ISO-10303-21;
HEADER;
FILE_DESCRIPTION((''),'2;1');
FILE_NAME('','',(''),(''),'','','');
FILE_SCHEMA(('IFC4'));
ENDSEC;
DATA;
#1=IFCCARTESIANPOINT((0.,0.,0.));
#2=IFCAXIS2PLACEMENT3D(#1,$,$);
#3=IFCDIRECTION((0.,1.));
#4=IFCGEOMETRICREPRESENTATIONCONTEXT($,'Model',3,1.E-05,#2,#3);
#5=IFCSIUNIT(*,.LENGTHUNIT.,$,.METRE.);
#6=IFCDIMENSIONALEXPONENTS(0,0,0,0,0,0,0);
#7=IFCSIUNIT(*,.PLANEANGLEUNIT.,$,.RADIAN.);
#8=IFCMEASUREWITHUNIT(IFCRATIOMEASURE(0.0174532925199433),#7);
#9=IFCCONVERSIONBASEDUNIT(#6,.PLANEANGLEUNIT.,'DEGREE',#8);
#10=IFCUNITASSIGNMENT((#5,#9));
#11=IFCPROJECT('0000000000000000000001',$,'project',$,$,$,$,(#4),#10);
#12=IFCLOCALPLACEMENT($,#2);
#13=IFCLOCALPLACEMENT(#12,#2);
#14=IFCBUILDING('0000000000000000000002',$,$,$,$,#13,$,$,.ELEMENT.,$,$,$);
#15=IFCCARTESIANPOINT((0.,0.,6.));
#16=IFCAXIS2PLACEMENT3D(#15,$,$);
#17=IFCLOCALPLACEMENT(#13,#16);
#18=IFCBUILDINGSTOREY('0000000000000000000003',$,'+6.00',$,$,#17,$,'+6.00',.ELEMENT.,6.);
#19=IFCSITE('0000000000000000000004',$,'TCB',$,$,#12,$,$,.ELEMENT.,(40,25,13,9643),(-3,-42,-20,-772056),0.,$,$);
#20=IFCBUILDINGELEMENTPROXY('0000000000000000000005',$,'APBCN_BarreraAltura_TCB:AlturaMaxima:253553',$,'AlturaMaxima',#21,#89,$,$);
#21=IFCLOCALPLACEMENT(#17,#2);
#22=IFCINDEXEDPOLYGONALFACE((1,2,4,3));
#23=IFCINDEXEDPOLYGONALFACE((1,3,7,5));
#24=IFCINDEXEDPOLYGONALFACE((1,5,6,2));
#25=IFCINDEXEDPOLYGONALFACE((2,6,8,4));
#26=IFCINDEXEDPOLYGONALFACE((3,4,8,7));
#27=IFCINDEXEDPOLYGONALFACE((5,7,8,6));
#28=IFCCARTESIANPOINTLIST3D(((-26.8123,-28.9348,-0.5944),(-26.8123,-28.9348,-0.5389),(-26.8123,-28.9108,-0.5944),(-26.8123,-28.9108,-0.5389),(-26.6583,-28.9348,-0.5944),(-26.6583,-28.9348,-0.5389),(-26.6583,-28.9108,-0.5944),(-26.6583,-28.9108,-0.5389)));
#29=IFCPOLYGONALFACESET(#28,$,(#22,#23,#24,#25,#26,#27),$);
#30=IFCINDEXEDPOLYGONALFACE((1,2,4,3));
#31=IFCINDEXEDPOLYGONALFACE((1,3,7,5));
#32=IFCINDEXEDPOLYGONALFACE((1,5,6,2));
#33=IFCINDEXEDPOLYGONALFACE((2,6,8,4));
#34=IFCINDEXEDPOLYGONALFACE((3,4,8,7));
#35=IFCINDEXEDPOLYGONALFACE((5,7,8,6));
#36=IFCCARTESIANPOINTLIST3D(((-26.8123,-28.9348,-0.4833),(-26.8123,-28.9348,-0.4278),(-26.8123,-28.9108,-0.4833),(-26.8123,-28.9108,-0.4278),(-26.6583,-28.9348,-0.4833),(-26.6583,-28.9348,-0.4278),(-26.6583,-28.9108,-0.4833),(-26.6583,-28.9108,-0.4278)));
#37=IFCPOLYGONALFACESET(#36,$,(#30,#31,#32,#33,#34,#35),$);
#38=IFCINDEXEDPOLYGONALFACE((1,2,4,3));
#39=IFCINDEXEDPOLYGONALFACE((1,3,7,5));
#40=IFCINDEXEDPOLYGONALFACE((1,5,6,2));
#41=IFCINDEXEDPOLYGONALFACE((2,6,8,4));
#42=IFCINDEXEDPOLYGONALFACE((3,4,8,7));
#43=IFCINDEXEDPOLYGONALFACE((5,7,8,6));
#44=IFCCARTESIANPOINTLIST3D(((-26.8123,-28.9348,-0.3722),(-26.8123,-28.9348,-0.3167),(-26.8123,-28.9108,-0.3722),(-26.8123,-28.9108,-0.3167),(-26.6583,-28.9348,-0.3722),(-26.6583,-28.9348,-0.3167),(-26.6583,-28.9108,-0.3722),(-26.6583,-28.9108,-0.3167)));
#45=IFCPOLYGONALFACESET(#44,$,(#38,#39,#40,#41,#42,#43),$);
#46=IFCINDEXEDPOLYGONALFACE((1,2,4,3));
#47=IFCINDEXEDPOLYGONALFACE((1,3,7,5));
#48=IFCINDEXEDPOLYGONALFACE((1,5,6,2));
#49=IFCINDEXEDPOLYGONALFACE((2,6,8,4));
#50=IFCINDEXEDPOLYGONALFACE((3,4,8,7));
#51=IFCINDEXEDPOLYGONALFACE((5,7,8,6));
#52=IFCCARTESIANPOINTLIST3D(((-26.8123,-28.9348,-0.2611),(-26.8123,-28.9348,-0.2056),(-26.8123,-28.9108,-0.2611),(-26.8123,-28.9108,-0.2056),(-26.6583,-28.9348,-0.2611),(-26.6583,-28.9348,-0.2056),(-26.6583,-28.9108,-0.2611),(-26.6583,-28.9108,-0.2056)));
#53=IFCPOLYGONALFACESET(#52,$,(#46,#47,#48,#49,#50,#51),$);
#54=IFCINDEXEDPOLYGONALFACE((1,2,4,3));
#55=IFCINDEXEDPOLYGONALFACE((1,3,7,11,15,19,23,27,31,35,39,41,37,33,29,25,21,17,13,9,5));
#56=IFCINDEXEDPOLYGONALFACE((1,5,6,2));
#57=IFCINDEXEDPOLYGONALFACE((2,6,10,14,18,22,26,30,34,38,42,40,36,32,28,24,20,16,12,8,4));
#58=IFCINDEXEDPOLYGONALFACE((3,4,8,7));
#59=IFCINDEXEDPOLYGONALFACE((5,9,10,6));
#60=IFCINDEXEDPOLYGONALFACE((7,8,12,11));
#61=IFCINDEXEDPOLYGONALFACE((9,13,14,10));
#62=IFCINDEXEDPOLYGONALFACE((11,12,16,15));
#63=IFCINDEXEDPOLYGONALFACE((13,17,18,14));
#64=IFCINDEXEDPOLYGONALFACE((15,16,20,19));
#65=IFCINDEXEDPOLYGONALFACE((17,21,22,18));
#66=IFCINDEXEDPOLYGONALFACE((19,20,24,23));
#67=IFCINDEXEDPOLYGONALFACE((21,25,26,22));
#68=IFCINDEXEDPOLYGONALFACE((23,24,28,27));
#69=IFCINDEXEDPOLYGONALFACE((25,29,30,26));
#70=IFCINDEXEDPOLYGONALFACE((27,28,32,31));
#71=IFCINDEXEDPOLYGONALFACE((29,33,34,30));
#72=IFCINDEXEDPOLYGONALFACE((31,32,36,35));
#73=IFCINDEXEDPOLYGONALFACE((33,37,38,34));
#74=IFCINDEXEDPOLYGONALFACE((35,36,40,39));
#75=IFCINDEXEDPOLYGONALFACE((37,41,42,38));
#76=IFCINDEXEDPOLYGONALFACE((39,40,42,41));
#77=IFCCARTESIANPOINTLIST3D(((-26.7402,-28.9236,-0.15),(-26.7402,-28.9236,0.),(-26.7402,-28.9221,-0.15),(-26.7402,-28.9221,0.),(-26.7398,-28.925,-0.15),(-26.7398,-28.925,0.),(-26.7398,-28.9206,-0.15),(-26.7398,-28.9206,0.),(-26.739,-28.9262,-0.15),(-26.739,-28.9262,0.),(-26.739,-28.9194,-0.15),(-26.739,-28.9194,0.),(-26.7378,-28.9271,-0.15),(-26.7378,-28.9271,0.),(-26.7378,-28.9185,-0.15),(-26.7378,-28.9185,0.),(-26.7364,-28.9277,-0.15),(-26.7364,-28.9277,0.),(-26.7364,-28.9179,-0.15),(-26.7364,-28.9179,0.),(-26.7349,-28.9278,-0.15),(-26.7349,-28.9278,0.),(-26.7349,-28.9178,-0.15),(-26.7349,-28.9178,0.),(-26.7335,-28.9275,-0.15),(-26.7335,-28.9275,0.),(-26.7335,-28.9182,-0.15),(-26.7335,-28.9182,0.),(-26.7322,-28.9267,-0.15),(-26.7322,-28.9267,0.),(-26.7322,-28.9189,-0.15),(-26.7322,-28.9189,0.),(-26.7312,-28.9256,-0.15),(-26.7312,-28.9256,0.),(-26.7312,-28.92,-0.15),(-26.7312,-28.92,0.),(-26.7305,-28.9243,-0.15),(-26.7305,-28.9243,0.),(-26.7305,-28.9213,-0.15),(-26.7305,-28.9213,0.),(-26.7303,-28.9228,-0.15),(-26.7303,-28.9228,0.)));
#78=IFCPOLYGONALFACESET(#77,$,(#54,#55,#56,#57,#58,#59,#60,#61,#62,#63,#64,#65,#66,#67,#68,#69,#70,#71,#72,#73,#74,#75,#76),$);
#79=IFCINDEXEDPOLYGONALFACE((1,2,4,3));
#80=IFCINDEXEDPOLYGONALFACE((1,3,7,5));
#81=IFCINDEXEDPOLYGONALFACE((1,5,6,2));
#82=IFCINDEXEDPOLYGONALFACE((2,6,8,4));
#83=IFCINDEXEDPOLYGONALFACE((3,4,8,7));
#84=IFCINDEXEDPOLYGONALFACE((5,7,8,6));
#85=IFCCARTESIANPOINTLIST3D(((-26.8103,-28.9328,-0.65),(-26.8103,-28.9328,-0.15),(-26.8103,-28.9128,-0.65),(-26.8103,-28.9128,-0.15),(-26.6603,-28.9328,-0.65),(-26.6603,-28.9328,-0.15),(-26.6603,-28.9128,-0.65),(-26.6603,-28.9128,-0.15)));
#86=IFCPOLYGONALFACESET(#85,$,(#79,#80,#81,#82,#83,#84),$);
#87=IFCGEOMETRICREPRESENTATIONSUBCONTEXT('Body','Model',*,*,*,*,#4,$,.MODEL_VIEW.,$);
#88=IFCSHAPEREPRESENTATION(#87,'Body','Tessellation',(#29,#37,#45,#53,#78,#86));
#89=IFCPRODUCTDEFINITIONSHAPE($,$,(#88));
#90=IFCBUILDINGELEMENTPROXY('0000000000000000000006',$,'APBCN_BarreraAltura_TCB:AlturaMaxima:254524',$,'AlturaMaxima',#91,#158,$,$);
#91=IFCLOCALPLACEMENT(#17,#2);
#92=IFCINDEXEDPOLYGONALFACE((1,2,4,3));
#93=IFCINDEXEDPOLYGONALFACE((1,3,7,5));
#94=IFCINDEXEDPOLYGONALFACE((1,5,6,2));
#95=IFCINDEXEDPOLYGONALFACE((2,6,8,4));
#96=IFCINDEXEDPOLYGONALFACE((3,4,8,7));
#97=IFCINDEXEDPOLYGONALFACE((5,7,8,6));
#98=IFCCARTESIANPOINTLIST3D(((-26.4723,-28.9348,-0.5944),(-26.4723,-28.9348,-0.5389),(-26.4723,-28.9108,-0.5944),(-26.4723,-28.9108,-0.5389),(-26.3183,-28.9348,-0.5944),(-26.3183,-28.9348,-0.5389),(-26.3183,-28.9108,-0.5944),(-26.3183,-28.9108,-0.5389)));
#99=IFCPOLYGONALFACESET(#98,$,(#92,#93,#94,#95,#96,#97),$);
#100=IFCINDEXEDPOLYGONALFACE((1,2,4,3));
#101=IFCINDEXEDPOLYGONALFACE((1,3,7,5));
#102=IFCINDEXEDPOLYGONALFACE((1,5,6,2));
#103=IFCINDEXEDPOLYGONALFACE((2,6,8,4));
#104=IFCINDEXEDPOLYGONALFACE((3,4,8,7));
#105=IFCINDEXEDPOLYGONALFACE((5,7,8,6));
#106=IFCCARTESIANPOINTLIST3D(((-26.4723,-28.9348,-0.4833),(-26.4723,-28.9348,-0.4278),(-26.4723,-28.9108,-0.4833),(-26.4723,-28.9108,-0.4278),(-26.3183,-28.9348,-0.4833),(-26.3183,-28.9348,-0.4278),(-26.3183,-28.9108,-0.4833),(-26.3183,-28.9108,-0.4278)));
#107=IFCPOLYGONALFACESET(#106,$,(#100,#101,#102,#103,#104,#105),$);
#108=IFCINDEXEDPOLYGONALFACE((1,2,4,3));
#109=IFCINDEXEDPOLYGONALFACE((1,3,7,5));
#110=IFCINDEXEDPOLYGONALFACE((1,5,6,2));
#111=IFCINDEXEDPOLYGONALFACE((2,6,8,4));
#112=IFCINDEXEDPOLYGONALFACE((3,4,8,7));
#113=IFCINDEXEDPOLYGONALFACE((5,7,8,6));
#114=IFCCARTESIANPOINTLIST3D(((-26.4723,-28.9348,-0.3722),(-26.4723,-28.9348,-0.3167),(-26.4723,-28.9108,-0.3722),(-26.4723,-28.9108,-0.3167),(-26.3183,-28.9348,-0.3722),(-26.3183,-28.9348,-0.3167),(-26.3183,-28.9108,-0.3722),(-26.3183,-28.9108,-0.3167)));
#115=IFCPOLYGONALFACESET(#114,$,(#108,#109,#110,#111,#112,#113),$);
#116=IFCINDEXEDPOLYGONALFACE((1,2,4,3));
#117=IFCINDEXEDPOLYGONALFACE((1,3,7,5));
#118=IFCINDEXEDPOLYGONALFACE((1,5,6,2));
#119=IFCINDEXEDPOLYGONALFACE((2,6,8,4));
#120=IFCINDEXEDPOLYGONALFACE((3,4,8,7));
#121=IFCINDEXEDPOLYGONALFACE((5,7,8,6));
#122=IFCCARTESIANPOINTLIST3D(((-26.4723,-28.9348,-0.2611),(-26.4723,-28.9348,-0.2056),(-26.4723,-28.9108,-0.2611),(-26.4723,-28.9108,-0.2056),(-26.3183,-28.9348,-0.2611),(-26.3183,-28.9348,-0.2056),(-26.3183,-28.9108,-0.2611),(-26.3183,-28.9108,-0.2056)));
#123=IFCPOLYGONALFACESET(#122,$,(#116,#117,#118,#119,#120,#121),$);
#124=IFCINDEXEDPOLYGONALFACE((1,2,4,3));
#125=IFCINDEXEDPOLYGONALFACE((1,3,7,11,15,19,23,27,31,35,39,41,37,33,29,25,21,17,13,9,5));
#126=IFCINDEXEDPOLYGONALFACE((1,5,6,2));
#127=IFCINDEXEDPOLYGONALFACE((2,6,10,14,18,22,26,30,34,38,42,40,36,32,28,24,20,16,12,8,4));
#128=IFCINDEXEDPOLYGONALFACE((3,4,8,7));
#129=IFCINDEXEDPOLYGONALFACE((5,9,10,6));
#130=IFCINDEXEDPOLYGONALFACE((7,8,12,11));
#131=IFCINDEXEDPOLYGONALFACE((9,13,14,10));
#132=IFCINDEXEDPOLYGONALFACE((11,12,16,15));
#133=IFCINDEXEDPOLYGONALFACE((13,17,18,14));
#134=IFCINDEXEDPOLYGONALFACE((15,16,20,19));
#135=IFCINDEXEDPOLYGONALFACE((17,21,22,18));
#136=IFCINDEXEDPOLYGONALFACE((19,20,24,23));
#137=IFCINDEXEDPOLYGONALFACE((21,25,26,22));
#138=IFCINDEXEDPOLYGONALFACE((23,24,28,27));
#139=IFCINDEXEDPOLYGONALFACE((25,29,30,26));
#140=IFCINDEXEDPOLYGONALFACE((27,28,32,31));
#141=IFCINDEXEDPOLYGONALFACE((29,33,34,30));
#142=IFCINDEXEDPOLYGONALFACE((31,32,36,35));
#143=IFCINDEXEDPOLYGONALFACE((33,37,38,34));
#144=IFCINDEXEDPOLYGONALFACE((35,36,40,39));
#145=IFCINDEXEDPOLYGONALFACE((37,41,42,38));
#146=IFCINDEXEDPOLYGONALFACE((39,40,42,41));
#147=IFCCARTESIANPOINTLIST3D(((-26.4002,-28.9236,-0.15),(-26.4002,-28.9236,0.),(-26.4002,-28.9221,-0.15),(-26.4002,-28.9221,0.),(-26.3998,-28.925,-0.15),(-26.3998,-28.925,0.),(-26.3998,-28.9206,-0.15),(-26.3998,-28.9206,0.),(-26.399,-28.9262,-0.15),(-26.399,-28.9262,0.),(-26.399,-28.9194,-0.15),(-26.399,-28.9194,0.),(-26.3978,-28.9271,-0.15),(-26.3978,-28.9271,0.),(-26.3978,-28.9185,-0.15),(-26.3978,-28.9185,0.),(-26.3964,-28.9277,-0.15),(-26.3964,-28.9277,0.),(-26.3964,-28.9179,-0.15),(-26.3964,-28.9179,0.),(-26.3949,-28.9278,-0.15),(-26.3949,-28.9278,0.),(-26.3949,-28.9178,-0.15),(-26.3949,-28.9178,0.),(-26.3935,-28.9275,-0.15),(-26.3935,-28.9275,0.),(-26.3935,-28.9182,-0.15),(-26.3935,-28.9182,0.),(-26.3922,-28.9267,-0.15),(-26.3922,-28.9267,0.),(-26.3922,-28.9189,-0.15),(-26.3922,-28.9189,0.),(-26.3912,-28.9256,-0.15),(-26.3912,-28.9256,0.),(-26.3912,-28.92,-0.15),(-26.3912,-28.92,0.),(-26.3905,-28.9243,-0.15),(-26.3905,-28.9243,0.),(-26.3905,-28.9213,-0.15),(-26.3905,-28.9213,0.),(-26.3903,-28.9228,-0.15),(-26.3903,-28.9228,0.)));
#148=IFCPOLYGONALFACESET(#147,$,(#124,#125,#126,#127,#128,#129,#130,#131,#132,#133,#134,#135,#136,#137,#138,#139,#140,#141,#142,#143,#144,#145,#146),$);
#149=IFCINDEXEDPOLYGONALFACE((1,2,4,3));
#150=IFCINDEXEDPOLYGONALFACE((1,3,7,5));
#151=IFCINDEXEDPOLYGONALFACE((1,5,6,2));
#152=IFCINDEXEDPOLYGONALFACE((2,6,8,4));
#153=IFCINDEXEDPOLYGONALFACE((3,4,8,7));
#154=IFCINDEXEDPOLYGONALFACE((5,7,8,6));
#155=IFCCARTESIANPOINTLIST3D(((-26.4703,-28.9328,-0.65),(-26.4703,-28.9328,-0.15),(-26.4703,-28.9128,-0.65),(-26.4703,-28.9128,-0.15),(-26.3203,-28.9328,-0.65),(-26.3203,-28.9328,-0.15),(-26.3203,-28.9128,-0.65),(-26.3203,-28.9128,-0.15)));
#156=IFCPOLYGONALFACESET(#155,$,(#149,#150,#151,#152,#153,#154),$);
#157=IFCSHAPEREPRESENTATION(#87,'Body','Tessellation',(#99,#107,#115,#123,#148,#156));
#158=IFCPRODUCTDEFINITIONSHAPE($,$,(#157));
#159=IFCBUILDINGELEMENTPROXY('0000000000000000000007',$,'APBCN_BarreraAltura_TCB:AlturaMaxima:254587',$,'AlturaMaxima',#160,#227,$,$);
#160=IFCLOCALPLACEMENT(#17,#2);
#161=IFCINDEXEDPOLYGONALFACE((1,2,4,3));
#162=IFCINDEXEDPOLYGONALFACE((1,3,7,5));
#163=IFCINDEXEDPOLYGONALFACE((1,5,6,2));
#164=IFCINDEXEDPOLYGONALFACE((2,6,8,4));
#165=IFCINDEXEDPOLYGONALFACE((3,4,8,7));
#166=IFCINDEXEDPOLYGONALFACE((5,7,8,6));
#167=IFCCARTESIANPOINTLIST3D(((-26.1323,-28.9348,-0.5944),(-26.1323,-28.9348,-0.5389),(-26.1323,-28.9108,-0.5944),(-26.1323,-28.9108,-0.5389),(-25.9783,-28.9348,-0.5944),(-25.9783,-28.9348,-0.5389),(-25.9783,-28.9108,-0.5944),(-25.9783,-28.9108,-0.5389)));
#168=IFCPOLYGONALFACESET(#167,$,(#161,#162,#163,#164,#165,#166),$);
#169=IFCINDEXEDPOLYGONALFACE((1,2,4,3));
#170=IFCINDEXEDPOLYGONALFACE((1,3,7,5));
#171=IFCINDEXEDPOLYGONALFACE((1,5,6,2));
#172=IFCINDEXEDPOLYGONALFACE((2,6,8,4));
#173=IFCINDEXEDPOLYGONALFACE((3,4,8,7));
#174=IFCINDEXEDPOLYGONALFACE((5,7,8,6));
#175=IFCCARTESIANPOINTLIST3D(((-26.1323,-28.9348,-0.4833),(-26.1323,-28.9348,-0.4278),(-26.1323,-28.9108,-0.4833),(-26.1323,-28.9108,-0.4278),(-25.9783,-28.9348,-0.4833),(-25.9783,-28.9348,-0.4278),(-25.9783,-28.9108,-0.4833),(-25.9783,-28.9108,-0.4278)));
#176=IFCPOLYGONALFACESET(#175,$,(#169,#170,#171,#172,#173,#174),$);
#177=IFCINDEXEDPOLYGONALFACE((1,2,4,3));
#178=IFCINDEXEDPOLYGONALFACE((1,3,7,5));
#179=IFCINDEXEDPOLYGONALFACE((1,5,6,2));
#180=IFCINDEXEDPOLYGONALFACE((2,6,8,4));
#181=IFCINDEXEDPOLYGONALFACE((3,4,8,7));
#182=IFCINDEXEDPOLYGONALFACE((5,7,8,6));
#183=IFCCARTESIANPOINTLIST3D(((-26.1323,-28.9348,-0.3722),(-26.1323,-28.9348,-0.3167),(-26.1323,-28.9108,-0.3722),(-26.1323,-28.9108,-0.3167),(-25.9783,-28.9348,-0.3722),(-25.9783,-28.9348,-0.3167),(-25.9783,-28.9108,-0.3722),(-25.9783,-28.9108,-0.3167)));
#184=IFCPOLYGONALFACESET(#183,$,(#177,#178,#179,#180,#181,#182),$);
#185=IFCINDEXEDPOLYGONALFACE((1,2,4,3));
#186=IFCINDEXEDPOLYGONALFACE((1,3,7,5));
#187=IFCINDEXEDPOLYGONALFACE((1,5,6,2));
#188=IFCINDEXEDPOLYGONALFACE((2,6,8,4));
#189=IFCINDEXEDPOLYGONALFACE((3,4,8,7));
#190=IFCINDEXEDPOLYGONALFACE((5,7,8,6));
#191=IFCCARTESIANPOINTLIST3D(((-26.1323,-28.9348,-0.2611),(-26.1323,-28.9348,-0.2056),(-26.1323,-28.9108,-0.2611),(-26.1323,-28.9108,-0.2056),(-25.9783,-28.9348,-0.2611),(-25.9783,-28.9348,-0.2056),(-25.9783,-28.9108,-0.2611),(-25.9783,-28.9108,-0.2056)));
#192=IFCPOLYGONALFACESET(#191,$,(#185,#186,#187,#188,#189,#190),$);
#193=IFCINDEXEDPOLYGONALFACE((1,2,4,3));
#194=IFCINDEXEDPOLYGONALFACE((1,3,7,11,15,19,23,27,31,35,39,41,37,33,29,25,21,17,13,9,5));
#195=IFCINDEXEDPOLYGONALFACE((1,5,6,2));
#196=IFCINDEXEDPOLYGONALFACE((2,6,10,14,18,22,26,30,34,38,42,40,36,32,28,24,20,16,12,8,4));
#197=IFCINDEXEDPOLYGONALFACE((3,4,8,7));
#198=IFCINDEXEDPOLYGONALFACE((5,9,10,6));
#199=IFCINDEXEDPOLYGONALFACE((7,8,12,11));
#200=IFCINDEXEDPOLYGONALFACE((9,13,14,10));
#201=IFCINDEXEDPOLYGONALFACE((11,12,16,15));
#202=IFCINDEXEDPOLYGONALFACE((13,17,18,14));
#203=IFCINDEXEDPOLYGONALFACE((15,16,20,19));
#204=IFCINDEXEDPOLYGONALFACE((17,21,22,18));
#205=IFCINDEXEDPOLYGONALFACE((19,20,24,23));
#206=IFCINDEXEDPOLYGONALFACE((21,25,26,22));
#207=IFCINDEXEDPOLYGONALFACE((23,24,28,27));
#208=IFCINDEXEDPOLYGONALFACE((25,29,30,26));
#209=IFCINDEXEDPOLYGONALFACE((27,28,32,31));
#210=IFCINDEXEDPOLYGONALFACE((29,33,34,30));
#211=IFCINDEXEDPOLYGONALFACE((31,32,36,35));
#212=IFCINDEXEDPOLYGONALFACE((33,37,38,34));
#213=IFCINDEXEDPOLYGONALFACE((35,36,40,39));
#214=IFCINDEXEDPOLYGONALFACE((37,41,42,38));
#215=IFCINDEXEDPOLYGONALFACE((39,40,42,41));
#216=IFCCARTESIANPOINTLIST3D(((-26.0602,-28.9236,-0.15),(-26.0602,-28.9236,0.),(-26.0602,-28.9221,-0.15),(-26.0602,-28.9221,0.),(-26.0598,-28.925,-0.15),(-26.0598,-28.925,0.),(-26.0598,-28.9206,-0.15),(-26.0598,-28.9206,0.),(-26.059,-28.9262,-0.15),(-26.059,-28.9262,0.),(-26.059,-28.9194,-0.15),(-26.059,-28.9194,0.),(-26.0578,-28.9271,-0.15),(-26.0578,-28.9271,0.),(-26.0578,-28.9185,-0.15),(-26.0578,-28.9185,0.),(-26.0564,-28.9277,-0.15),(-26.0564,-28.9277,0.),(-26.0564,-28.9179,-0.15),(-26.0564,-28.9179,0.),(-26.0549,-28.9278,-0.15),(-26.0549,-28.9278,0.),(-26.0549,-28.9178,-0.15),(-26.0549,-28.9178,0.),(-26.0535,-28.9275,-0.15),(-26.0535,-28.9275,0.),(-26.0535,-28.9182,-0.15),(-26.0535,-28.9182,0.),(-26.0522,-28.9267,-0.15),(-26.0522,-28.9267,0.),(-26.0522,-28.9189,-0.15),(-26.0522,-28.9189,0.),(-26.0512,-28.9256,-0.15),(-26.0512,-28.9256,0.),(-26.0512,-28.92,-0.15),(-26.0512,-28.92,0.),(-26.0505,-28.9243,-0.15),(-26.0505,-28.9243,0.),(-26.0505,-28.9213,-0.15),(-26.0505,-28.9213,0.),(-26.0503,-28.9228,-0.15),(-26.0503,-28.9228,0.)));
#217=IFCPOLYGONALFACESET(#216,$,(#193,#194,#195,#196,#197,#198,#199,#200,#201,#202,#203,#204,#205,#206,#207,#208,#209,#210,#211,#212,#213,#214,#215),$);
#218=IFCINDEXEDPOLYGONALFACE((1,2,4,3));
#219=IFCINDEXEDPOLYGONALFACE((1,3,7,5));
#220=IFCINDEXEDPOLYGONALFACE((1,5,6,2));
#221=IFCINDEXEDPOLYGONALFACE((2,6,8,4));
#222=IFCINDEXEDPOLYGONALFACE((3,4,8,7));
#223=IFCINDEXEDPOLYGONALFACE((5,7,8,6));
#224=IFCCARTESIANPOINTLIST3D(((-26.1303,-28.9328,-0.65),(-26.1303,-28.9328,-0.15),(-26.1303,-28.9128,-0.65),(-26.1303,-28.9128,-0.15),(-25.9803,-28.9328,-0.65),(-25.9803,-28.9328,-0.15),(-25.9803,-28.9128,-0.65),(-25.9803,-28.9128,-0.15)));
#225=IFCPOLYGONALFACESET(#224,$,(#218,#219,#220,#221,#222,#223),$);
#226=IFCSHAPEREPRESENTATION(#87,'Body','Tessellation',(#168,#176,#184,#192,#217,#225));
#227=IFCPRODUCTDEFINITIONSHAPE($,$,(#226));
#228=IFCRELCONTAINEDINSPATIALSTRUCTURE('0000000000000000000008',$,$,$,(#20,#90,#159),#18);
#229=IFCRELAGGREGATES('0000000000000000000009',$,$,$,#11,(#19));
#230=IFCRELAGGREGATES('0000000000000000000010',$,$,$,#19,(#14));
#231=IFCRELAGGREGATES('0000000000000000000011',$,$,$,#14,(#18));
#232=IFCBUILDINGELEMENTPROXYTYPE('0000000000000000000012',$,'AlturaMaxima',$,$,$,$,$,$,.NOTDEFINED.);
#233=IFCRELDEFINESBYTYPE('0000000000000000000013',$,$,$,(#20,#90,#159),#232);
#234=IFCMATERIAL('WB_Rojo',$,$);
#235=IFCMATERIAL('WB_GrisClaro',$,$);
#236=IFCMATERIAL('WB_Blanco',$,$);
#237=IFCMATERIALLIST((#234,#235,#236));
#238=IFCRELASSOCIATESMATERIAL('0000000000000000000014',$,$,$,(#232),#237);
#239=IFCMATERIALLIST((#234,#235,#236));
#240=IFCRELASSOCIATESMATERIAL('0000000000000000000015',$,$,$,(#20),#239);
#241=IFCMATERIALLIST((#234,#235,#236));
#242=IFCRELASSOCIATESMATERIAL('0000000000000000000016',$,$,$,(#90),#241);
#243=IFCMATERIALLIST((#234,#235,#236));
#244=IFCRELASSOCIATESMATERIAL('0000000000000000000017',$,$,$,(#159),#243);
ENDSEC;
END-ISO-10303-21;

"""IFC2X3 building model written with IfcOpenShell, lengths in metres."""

from ifc_helpers import new_model, entity, si_unit, converted_unit, direction, frame, frame_2d, origin, origin_2d_with_axis, place, context, subcontext, project, spatial, rectangle, circle, extrude, source, transform, mapped, material, material_list, type_object, type_shapes, element, save


model = new_model("IFC2X3")

# Units and contexts
model_context = context("Model", 3, precision=1e-05, world=origin(), true_north=direction((0.0, 1.0)))
body_context = subcontext(model_context, "Body", "Model", "MODEL_VIEW")
ifc_project = project(units=[si_unit("LENGTHUNIT", "METRE"), converted_unit("PLANEANGLEUNIT", "DEGREE", entity("IfcRatioMeasure", 0.0174532925199433), si_unit("PLANEANGLEUNIT", "RADIAN"), dimensions=[0, 0, 0, 0, 0, 0, 0])], contexts=[model_context])

# Site, building, storey
site_placement = place(None, origin())
site = spatial("IfcSite", under=ifc_project, at=site_placement, Name="TCB", CompositionType="ELEMENT", RefLatitude=(40, 25, 13, 9643), RefLongitude=(-3, -42, -20, -772056), RefElevation=0.0)
building_placement = place(site_placement, origin())
building = spatial("IfcBuilding", under=site, at=building_placement, CompositionType="ELEMENT")
storey_placement = place(building_placement, frame((0.0, 0.0, 6.0)))
storey = spatial("IfcBuildingStorey", under=building, at=storey_placement, Name="+6.00", LongName="+6.00", CompositionType="ELEMENT", Elevation=6.0)

# Building element proxies
ifc_material_1 = material(Name="WB_Rojo")
ifc_material_2 = material(Name="WB_GrisClaro")
ifc_material_3 = material(Name="WB_Blanco")
ifc_material_list_1 = material_list([ifc_material_1, ifc_material_2, ifc_material_3])
ifc_material_list_2 = material_list([ifc_material_1, ifc_material_2, ifc_material_3])
building_element_proxy_type = type_object("IfcBuildingElementProxyType", Name="AlturaMaxima", PredefinedType="NOTDEFINED", material=ifc_material_list_2)
shared_shape = source(origin(), body_context, "Body", "SweptSolid", [
    extrude(rectangle(XDim=0.154, YDim=0.024, at=frame_2d((0.0, 0.0), x_axis=(1.0, 0.0))), frame((0.0, 0.0, -0.5944), z_axis=(0.0, 0.0, 1.0), x_axis=(-1.0, 0.0, 0.0)), (0.0, 0.0, 1.0), 0.0556),
    extrude(rectangle(XDim=0.154, YDim=0.024, at=frame_2d((0.0, 0.0), x_axis=(1.0, 0.0))), frame((0.0, 0.0, -0.4833), z_axis=(0.0, 0.0, 1.0), x_axis=(-1.0, 0.0, 0.0)), (0.0, 0.0, 1.0), 0.0556),
    extrude(rectangle(XDim=0.154, YDim=0.024, at=frame_2d((0.0, 0.0), x_axis=(1.0, 0.0))), frame((0.0, 0.0, -0.3722), z_axis=(0.0, 0.0, 1.0), x_axis=(-1.0, 0.0, 0.0)), (0.0, 0.0, 1.0), 0.0556),
    extrude(rectangle(XDim=0.154, YDim=0.024, at=frame_2d((0.0, 0.0), x_axis=(1.0, 0.0))), frame((0.0, 0.0, -0.2611), z_axis=(0.0, 0.0, 1.0), x_axis=(-1.0, 0.0, 0.0)), (0.0, 0.0, 1.0), 0.0556),
    extrude(circle(Radius=0.005, at=frame_2d((0.0, 0.0), x_axis=(1.0, 0.0))), frame((0.0, 0.0, -0.15)), (0.0, 0.0, 1.0), 0.15),
    extrude(rectangle(XDim=0.02, YDim=0.15, at=origin_2d_with_axis()), frame((0.0, 0.0, -0.65), z_axis=(0.0, 0.0, 1.0), x_axis=(0.0, 1.0, 0.0)), (0.0, 0.0, 1.0), 0.5),
])
type_shapes(building_element_proxy_type, [shared_shape])
proxy_1_placement = place(storey_placement, frame((-26.7353, -28.9228, 0.0)))
element("IfcBuildingElementProxy", 1, at=proxy_1_placement, inside=storey, type_object=building_element_proxy_type, material=ifc_material_list_1, Name="APBCN_BarreraAltura_TCB:AlturaMaxima:253553", ObjectType="AlturaMaxima", context=body_context, shape_type="MappedRepresentation", body=[
    mapped(shared_shape, transform((0.0, 0.0, 0.0), scale=1.0)),
])
ifc_material_list_3 = material_list([ifc_material_1, ifc_material_2, ifc_material_3])
proxy_2_placement = place(storey_placement, frame((-26.3953, -28.9228, 0.0)))
element("IfcBuildingElementProxy", 2, at=proxy_2_placement, inside=storey, type_object=building_element_proxy_type, material=ifc_material_list_3, Name="APBCN_BarreraAltura_TCB:AlturaMaxima:254524", ObjectType="AlturaMaxima", context=body_context, shape_type="MappedRepresentation", body=[
    mapped(shared_shape, transform((0.0, 0.0, 0.0), scale=1.0)),
])
ifc_material_list_4 = material_list([ifc_material_1, ifc_material_2, ifc_material_3])
proxy_3_placement = place(storey_placement, frame((-26.0553, -28.9228, 0.0)))
element("IfcBuildingElementProxy", 3, at=proxy_3_placement, inside=storey, type_object=building_element_proxy_type, material=ifc_material_list_4, Name="APBCN_BarreraAltura_TCB:AlturaMaxima:254587", ObjectType="AlturaMaxima", context=body_context, shape_type="MappedRepresentation", body=[
    mapped(shared_shape, transform((0.0, 0.0, 0.0), scale=1.0)),
])

save(model, "model.ifc")
